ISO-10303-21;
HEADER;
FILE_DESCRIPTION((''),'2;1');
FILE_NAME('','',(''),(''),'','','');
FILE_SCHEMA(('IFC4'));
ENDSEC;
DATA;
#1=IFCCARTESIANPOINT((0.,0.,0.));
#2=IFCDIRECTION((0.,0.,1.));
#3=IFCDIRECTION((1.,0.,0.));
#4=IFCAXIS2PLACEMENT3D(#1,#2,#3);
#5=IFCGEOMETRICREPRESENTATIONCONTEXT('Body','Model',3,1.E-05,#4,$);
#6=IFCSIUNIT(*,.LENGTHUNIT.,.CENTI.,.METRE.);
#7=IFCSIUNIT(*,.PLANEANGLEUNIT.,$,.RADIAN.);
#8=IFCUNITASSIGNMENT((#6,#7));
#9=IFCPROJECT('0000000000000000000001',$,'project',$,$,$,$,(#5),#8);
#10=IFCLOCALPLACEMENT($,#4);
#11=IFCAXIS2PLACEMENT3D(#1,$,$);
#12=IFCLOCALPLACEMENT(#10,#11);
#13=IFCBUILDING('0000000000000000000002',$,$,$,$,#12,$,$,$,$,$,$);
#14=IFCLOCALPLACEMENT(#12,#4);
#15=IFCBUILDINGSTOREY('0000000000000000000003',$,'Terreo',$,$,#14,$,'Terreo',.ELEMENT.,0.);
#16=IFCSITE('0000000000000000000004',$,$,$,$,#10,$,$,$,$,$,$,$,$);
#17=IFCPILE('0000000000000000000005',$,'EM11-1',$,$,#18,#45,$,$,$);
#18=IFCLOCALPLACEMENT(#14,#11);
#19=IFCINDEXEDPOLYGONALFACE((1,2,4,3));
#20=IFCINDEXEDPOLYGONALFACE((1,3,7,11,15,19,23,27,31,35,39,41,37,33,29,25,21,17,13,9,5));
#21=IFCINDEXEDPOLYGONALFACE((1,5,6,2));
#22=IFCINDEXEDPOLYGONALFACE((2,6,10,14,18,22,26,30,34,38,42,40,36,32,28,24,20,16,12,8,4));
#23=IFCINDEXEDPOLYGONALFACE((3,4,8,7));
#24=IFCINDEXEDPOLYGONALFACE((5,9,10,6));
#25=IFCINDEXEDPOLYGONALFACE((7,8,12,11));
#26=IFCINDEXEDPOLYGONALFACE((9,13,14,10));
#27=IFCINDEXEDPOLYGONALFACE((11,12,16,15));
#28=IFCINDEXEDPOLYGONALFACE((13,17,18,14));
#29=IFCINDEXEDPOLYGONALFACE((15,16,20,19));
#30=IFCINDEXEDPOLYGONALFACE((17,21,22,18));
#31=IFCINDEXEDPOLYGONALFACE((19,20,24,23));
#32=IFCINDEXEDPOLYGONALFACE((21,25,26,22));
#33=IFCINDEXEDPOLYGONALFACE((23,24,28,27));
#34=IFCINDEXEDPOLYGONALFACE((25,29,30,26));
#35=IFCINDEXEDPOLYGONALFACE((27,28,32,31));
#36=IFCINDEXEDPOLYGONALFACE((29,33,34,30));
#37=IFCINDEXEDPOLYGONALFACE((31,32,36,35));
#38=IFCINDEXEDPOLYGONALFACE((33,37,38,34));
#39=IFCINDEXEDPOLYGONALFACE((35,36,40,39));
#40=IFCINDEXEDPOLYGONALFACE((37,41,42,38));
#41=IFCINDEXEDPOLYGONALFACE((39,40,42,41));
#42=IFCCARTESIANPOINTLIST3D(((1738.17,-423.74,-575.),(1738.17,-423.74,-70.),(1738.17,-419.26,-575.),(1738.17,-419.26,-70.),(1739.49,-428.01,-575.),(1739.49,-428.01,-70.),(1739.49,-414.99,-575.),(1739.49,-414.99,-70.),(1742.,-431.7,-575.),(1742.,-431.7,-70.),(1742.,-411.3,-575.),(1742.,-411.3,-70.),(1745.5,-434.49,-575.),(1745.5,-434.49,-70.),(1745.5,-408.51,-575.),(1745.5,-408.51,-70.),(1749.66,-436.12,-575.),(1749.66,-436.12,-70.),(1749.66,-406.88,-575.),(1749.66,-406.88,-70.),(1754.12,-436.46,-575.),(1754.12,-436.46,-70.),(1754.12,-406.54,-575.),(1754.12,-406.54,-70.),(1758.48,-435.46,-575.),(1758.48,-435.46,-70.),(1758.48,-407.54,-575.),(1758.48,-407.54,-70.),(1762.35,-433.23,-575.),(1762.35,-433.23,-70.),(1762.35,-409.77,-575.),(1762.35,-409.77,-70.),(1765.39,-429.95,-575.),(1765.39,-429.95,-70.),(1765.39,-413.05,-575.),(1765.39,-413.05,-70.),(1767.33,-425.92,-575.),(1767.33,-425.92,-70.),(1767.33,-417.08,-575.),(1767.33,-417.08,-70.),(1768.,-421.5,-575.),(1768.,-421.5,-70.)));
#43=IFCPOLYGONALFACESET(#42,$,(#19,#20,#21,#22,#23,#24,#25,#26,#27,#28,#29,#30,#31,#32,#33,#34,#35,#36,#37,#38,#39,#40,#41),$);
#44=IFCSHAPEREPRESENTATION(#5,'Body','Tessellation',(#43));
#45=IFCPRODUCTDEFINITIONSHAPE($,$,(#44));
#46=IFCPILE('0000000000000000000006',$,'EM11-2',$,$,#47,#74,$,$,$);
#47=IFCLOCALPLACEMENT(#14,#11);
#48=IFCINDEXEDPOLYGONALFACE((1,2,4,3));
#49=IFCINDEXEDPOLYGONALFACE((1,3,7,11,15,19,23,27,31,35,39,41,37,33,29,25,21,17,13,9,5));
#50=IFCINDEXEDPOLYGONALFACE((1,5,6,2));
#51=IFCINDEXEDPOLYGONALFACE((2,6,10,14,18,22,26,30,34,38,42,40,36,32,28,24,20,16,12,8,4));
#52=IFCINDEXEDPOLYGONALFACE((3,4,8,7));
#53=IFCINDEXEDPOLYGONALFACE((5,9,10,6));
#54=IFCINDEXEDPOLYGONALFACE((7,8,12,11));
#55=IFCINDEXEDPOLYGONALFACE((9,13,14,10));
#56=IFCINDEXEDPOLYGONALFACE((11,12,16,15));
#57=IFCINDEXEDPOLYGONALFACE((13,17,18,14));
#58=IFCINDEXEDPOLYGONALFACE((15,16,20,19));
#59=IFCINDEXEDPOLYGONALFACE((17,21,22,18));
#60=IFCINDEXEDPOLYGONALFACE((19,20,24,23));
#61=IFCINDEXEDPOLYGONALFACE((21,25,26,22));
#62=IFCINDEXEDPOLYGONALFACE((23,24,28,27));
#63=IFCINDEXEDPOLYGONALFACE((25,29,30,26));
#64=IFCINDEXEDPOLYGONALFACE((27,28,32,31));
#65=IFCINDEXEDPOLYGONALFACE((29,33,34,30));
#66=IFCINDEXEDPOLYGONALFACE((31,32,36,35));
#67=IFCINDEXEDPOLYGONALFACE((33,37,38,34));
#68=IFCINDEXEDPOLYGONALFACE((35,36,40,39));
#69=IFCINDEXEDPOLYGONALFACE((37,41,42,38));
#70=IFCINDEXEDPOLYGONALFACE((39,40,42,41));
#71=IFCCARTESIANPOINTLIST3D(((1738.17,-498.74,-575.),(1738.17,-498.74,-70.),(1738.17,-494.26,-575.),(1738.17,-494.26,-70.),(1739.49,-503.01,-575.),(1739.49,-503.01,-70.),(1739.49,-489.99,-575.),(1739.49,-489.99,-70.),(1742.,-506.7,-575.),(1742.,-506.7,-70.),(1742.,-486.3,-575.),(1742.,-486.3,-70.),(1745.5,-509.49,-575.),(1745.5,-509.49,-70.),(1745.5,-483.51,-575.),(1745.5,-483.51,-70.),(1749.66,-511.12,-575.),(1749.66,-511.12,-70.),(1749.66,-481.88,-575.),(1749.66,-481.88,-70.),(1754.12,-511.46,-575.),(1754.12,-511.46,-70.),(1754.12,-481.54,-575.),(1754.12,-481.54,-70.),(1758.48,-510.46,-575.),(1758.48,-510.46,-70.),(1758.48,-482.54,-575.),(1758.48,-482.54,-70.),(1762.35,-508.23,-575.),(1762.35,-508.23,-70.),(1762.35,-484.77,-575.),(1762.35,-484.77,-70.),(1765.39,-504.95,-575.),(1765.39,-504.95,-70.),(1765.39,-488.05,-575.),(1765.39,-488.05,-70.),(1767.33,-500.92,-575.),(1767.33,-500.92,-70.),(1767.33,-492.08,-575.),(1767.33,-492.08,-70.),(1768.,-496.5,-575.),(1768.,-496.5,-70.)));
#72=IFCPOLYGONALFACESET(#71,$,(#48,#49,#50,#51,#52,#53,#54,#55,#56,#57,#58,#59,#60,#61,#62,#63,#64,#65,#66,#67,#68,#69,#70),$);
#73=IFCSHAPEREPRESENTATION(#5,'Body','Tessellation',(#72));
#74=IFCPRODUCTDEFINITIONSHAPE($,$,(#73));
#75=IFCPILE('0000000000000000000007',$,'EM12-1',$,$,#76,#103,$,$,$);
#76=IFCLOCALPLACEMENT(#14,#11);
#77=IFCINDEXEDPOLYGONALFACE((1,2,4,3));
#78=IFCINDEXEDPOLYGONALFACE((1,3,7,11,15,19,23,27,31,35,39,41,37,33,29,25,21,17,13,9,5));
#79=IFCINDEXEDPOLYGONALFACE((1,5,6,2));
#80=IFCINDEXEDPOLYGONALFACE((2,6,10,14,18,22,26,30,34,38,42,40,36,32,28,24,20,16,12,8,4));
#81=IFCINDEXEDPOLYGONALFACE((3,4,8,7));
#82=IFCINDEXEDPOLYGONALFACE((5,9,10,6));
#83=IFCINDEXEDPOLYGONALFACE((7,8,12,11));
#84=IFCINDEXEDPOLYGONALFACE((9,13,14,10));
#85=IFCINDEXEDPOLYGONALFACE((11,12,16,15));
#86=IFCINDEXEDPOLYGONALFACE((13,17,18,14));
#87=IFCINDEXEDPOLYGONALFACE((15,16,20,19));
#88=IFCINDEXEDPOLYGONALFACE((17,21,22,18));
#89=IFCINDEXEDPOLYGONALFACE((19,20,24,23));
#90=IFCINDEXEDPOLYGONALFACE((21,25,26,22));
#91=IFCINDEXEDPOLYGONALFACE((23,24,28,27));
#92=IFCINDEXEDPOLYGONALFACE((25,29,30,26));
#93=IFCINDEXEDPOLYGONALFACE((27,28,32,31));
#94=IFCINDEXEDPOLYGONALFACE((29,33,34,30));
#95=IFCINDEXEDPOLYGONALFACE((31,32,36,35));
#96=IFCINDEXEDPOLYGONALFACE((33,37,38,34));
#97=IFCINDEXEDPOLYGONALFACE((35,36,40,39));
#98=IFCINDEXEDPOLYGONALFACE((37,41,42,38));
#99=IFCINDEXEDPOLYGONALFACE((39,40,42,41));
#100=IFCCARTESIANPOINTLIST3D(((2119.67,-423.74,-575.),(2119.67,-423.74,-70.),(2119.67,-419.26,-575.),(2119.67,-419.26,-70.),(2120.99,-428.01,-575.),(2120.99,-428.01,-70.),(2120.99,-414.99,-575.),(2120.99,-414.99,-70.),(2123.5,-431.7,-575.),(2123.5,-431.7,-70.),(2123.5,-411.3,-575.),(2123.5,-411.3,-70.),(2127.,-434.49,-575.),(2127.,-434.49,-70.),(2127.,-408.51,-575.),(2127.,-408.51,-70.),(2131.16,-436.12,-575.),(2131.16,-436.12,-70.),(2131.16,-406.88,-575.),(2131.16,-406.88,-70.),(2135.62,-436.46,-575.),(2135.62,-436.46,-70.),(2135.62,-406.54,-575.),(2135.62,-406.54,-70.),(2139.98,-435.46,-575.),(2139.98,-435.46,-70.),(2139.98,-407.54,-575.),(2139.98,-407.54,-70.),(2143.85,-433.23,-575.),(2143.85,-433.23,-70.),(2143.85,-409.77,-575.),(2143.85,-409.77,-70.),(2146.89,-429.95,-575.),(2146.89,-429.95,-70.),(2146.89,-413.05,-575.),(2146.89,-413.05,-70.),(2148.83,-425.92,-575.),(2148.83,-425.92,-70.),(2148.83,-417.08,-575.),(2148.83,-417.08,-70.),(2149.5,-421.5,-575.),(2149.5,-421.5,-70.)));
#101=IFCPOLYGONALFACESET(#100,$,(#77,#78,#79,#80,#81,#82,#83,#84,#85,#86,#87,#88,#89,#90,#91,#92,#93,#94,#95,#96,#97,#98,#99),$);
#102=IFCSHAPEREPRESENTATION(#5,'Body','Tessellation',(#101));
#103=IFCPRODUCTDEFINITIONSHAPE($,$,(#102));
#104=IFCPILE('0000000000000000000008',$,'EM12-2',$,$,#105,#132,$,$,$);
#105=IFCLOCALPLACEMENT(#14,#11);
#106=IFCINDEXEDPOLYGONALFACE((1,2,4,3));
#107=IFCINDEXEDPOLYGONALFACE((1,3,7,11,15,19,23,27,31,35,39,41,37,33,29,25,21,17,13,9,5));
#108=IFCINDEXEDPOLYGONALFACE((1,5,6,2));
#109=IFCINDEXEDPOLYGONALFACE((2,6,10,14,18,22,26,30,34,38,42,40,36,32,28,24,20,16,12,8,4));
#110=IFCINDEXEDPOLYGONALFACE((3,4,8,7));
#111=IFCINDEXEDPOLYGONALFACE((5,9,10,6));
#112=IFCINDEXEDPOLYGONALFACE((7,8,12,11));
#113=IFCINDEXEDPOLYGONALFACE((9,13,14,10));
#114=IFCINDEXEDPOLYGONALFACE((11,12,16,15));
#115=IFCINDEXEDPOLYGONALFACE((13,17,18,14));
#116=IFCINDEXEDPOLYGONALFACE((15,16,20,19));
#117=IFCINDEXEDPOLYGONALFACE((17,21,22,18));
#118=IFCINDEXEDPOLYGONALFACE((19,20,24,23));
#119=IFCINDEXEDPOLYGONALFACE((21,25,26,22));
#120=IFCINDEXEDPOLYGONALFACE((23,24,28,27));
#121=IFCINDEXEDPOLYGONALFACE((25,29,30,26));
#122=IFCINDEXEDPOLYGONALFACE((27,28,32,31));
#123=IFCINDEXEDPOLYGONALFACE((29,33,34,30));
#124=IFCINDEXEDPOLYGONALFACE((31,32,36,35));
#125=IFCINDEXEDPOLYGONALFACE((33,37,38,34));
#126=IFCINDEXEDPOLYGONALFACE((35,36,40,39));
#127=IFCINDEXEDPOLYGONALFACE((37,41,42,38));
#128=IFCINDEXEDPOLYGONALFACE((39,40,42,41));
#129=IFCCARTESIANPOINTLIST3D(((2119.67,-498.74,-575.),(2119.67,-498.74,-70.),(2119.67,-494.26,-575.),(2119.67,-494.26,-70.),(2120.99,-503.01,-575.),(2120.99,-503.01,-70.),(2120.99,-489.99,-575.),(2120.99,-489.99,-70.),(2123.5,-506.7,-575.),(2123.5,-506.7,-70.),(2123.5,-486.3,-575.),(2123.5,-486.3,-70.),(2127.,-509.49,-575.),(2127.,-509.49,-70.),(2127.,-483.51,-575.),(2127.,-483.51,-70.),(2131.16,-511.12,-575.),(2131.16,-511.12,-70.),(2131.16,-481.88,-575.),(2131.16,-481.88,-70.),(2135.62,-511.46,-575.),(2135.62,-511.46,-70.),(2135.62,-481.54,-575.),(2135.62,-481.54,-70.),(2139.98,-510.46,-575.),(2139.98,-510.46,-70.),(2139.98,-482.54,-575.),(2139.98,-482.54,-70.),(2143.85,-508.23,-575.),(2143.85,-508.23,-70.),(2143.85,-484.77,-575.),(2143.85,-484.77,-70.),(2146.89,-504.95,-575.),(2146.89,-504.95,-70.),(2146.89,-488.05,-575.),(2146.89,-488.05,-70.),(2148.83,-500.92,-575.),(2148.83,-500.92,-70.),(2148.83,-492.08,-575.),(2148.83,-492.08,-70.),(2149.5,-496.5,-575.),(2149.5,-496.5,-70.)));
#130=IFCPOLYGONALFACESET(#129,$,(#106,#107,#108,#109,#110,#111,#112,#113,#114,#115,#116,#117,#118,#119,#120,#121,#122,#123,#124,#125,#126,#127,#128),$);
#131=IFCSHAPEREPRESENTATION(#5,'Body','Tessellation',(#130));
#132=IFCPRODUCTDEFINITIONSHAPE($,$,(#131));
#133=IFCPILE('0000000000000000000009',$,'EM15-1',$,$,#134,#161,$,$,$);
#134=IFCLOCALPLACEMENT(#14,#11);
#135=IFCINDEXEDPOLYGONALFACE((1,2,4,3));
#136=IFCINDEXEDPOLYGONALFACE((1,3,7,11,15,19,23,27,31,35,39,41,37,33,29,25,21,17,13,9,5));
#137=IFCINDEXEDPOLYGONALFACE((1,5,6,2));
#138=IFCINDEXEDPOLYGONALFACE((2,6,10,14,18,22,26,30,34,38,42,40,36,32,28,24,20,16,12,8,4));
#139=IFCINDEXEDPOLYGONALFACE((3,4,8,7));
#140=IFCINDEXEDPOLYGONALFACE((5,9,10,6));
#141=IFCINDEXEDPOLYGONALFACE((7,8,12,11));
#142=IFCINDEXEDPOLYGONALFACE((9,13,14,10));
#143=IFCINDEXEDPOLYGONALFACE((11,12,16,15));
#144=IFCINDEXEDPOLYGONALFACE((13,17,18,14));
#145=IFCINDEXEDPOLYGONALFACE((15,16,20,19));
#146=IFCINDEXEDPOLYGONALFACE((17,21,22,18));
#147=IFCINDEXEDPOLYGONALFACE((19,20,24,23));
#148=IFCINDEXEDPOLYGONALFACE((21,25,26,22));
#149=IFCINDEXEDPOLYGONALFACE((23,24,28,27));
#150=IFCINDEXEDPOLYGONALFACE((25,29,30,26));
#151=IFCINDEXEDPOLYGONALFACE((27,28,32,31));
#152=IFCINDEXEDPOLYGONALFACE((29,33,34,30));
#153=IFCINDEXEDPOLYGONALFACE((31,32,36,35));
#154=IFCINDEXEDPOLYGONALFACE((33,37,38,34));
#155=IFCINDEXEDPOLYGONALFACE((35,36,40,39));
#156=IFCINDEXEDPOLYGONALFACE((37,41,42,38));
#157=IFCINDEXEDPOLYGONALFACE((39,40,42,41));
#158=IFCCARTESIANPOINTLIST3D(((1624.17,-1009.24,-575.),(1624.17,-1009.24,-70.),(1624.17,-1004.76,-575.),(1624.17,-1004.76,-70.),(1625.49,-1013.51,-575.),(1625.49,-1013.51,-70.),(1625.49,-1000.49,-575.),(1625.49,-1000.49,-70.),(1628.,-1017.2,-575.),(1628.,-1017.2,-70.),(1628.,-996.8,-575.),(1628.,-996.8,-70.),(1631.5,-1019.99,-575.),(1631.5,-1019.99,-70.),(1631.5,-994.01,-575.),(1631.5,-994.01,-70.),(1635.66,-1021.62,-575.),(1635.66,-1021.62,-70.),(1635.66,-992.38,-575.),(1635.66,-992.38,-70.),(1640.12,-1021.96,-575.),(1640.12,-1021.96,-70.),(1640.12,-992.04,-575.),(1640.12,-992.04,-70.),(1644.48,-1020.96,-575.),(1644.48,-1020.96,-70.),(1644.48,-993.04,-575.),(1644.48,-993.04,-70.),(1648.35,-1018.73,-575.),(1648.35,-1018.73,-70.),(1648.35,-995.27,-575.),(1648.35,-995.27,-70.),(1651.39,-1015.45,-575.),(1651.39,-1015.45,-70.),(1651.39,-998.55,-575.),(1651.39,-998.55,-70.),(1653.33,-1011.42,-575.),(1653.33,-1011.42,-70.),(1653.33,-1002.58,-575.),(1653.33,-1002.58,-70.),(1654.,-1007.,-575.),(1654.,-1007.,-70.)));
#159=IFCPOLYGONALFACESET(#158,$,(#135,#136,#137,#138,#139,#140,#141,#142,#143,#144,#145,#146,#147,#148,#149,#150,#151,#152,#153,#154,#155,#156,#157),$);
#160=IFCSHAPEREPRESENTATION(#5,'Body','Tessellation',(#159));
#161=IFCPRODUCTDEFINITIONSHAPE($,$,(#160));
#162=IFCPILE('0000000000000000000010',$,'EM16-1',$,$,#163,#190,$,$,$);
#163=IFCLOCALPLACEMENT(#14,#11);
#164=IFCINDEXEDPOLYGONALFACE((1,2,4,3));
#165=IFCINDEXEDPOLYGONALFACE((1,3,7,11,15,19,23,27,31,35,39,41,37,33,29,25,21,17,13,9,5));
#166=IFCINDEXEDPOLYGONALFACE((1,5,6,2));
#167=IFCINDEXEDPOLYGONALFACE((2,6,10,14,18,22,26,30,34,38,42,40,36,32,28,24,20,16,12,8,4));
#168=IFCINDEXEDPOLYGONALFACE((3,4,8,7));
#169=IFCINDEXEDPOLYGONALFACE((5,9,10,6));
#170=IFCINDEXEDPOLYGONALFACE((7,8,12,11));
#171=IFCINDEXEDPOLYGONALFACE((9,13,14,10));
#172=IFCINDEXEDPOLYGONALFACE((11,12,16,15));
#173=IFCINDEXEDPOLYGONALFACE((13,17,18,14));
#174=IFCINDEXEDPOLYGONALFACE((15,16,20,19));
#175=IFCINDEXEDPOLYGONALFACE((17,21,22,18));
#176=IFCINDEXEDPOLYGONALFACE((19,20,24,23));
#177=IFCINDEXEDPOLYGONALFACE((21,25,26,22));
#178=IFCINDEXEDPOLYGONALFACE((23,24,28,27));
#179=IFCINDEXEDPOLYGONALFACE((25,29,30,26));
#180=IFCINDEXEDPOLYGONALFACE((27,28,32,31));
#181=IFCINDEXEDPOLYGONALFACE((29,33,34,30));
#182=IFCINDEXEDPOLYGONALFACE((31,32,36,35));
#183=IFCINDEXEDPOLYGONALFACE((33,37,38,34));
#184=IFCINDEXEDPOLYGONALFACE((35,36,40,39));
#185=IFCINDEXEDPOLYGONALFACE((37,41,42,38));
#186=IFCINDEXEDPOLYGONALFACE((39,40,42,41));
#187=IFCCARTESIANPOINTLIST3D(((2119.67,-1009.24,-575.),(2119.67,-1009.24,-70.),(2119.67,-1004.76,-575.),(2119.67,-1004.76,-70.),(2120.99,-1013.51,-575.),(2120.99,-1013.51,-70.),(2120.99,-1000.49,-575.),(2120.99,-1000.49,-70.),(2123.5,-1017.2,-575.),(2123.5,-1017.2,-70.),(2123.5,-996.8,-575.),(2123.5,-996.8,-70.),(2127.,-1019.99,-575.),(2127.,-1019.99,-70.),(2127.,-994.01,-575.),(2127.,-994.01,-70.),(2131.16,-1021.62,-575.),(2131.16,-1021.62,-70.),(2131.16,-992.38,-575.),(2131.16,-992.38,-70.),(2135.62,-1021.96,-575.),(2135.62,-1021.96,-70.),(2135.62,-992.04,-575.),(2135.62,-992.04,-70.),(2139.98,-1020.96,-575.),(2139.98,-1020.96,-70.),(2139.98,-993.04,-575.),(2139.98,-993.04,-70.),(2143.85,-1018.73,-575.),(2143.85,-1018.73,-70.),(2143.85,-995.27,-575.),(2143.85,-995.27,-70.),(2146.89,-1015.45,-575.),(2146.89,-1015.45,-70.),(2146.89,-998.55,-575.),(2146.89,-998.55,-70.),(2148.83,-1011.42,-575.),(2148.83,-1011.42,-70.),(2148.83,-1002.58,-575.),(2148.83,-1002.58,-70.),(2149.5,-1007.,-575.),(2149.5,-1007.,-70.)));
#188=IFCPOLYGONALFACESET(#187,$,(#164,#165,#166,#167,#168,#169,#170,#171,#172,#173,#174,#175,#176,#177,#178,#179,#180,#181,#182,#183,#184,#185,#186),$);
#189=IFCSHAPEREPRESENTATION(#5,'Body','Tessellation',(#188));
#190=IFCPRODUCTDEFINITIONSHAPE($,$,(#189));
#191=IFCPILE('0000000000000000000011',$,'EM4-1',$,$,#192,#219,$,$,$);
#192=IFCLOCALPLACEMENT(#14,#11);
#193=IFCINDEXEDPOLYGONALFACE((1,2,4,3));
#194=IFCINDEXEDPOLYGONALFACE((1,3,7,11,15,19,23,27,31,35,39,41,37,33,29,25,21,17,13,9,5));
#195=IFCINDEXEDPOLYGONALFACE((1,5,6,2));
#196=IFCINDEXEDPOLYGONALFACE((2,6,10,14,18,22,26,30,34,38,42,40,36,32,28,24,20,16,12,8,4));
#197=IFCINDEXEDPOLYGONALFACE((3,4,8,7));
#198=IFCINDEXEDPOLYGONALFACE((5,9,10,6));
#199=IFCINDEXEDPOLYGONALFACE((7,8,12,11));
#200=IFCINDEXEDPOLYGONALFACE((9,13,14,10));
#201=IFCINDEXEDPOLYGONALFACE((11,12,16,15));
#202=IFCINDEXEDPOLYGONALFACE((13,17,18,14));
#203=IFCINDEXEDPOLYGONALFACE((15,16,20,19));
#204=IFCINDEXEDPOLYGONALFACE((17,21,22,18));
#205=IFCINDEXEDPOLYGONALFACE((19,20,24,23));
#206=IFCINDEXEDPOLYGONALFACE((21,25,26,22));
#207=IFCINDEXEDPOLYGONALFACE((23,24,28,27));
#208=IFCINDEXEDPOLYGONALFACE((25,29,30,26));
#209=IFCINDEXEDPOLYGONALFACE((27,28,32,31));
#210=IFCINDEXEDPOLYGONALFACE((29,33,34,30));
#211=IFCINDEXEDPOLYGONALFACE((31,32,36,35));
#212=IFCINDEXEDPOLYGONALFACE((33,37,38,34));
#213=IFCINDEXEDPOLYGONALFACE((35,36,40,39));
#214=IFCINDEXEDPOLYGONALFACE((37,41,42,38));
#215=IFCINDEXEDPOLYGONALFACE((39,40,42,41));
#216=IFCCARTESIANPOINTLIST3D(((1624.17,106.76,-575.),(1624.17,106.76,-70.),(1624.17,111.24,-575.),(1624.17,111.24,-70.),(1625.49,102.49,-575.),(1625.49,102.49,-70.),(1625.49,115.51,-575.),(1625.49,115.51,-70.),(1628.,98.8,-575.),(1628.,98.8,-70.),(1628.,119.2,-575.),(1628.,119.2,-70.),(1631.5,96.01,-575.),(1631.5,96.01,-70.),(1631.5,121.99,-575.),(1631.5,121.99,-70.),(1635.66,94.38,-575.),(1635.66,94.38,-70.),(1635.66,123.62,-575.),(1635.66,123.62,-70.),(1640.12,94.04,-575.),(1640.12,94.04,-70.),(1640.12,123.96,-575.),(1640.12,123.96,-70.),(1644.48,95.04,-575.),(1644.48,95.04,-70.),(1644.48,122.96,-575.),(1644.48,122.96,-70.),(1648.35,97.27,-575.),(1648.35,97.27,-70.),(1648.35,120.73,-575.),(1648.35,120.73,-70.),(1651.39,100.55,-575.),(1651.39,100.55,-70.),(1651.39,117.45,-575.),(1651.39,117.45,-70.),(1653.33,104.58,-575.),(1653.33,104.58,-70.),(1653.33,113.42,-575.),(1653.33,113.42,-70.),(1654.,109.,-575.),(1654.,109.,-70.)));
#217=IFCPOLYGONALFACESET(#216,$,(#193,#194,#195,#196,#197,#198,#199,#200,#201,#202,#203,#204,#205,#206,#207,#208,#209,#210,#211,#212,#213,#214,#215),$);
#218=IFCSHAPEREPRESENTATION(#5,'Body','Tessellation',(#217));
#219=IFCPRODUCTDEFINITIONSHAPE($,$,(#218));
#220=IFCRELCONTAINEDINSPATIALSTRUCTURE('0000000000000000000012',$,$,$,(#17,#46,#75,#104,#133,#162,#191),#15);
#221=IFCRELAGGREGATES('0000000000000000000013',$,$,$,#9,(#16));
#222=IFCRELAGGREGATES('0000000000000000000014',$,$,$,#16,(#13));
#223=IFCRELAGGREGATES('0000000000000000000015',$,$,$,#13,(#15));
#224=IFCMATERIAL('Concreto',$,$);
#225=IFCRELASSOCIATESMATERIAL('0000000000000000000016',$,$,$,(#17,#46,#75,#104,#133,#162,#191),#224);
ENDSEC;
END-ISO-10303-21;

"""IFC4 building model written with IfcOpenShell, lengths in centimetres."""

from ifc_helpers import new_model, si_unit, frame, origin, origin_with_axes, origin_2d_with_axis, place, context, project, spatial, circle, extrude, material, element, save


model = new_model("IFC4")

# Units and contexts
model_context = context("Model", 3, precision=1e-05, world=origin_with_axes(), identifier="Body")
ifc_project = project(units=[si_unit("LENGTHUNIT", "METRE", prefix="CENTI"), si_unit("PLANEANGLEUNIT", "RADIAN")], contexts=[model_context])

# Site, building, storey
site_placement = place(None, origin_with_axes())
site = spatial("IfcSite", under=ifc_project, at=site_placement)
building_placement = place(site_placement, origin())
building = spatial("IfcBuilding", under=site, at=building_placement)
storey_placement = place(building_placement, origin_with_axes())
storey = spatial("IfcBuildingStorey", under=building, at=storey_placement, Name="Terreo", LongName="Terreo", CompositionType="ELEMENT", Elevation=0.0)

# Piles
ifc_material = material(Name="Concreto")
for number, where, z_axis, x_axis, name in (
    (1, (1753.0, -421.5, -70.0), (0.0, 0.0, 1.0), (1.0, 0.0, 0.0), "EM11-1"),
    (2, (1753.0, -496.5, -70.0), (0.0, 0.0, 1.0), (1.0, 0.0, 0.0), "EM11-2"),
    (3, (2134.5, -421.5, -70.0), (0.0, 0.0, 1.0), (1.0, 0.0, 0.0), "EM12-1"),
    (4, (2134.5, -496.5, -70.0), (0.0, 0.0, 1.0), (1.0, 0.0, 0.0), "EM12-2"),
    (5, (1639.0, -1007.0, -70.0), (0.0, 0.0, 1.0), (1.0, 0.0, 0.0), "EM15-1"),
    (6, (2134.5, -1007.0, -70.0), (0.0, 0.0, 1.0), (1.0, 0.0, 0.0), "EM16-1"),
    (7, (1639.0, 109.0, -70.0), (0.0, 0.0, 1.0), (1.0, 0.0, 0.0), "EM4-1"),
):
    element("IfcPile", number, at=place(storey_placement, frame(where, z_axis=z_axis, x_axis=x_axis)), inside=storey, material=ifc_material, Name=name, context=model_context, shape_type="SweptSolid", body=[
        extrude(circle(Radius=15.0, at=origin_2d_with_axis()), frame((0.0, 0.0, -505.0), z_axis=(0.0, 0.0, 1.0), x_axis=(1.0, 0.0, 0.0)), (0.0, 0.0, 1.0), 505.0),
    ])

save(model, "model.ifc")
